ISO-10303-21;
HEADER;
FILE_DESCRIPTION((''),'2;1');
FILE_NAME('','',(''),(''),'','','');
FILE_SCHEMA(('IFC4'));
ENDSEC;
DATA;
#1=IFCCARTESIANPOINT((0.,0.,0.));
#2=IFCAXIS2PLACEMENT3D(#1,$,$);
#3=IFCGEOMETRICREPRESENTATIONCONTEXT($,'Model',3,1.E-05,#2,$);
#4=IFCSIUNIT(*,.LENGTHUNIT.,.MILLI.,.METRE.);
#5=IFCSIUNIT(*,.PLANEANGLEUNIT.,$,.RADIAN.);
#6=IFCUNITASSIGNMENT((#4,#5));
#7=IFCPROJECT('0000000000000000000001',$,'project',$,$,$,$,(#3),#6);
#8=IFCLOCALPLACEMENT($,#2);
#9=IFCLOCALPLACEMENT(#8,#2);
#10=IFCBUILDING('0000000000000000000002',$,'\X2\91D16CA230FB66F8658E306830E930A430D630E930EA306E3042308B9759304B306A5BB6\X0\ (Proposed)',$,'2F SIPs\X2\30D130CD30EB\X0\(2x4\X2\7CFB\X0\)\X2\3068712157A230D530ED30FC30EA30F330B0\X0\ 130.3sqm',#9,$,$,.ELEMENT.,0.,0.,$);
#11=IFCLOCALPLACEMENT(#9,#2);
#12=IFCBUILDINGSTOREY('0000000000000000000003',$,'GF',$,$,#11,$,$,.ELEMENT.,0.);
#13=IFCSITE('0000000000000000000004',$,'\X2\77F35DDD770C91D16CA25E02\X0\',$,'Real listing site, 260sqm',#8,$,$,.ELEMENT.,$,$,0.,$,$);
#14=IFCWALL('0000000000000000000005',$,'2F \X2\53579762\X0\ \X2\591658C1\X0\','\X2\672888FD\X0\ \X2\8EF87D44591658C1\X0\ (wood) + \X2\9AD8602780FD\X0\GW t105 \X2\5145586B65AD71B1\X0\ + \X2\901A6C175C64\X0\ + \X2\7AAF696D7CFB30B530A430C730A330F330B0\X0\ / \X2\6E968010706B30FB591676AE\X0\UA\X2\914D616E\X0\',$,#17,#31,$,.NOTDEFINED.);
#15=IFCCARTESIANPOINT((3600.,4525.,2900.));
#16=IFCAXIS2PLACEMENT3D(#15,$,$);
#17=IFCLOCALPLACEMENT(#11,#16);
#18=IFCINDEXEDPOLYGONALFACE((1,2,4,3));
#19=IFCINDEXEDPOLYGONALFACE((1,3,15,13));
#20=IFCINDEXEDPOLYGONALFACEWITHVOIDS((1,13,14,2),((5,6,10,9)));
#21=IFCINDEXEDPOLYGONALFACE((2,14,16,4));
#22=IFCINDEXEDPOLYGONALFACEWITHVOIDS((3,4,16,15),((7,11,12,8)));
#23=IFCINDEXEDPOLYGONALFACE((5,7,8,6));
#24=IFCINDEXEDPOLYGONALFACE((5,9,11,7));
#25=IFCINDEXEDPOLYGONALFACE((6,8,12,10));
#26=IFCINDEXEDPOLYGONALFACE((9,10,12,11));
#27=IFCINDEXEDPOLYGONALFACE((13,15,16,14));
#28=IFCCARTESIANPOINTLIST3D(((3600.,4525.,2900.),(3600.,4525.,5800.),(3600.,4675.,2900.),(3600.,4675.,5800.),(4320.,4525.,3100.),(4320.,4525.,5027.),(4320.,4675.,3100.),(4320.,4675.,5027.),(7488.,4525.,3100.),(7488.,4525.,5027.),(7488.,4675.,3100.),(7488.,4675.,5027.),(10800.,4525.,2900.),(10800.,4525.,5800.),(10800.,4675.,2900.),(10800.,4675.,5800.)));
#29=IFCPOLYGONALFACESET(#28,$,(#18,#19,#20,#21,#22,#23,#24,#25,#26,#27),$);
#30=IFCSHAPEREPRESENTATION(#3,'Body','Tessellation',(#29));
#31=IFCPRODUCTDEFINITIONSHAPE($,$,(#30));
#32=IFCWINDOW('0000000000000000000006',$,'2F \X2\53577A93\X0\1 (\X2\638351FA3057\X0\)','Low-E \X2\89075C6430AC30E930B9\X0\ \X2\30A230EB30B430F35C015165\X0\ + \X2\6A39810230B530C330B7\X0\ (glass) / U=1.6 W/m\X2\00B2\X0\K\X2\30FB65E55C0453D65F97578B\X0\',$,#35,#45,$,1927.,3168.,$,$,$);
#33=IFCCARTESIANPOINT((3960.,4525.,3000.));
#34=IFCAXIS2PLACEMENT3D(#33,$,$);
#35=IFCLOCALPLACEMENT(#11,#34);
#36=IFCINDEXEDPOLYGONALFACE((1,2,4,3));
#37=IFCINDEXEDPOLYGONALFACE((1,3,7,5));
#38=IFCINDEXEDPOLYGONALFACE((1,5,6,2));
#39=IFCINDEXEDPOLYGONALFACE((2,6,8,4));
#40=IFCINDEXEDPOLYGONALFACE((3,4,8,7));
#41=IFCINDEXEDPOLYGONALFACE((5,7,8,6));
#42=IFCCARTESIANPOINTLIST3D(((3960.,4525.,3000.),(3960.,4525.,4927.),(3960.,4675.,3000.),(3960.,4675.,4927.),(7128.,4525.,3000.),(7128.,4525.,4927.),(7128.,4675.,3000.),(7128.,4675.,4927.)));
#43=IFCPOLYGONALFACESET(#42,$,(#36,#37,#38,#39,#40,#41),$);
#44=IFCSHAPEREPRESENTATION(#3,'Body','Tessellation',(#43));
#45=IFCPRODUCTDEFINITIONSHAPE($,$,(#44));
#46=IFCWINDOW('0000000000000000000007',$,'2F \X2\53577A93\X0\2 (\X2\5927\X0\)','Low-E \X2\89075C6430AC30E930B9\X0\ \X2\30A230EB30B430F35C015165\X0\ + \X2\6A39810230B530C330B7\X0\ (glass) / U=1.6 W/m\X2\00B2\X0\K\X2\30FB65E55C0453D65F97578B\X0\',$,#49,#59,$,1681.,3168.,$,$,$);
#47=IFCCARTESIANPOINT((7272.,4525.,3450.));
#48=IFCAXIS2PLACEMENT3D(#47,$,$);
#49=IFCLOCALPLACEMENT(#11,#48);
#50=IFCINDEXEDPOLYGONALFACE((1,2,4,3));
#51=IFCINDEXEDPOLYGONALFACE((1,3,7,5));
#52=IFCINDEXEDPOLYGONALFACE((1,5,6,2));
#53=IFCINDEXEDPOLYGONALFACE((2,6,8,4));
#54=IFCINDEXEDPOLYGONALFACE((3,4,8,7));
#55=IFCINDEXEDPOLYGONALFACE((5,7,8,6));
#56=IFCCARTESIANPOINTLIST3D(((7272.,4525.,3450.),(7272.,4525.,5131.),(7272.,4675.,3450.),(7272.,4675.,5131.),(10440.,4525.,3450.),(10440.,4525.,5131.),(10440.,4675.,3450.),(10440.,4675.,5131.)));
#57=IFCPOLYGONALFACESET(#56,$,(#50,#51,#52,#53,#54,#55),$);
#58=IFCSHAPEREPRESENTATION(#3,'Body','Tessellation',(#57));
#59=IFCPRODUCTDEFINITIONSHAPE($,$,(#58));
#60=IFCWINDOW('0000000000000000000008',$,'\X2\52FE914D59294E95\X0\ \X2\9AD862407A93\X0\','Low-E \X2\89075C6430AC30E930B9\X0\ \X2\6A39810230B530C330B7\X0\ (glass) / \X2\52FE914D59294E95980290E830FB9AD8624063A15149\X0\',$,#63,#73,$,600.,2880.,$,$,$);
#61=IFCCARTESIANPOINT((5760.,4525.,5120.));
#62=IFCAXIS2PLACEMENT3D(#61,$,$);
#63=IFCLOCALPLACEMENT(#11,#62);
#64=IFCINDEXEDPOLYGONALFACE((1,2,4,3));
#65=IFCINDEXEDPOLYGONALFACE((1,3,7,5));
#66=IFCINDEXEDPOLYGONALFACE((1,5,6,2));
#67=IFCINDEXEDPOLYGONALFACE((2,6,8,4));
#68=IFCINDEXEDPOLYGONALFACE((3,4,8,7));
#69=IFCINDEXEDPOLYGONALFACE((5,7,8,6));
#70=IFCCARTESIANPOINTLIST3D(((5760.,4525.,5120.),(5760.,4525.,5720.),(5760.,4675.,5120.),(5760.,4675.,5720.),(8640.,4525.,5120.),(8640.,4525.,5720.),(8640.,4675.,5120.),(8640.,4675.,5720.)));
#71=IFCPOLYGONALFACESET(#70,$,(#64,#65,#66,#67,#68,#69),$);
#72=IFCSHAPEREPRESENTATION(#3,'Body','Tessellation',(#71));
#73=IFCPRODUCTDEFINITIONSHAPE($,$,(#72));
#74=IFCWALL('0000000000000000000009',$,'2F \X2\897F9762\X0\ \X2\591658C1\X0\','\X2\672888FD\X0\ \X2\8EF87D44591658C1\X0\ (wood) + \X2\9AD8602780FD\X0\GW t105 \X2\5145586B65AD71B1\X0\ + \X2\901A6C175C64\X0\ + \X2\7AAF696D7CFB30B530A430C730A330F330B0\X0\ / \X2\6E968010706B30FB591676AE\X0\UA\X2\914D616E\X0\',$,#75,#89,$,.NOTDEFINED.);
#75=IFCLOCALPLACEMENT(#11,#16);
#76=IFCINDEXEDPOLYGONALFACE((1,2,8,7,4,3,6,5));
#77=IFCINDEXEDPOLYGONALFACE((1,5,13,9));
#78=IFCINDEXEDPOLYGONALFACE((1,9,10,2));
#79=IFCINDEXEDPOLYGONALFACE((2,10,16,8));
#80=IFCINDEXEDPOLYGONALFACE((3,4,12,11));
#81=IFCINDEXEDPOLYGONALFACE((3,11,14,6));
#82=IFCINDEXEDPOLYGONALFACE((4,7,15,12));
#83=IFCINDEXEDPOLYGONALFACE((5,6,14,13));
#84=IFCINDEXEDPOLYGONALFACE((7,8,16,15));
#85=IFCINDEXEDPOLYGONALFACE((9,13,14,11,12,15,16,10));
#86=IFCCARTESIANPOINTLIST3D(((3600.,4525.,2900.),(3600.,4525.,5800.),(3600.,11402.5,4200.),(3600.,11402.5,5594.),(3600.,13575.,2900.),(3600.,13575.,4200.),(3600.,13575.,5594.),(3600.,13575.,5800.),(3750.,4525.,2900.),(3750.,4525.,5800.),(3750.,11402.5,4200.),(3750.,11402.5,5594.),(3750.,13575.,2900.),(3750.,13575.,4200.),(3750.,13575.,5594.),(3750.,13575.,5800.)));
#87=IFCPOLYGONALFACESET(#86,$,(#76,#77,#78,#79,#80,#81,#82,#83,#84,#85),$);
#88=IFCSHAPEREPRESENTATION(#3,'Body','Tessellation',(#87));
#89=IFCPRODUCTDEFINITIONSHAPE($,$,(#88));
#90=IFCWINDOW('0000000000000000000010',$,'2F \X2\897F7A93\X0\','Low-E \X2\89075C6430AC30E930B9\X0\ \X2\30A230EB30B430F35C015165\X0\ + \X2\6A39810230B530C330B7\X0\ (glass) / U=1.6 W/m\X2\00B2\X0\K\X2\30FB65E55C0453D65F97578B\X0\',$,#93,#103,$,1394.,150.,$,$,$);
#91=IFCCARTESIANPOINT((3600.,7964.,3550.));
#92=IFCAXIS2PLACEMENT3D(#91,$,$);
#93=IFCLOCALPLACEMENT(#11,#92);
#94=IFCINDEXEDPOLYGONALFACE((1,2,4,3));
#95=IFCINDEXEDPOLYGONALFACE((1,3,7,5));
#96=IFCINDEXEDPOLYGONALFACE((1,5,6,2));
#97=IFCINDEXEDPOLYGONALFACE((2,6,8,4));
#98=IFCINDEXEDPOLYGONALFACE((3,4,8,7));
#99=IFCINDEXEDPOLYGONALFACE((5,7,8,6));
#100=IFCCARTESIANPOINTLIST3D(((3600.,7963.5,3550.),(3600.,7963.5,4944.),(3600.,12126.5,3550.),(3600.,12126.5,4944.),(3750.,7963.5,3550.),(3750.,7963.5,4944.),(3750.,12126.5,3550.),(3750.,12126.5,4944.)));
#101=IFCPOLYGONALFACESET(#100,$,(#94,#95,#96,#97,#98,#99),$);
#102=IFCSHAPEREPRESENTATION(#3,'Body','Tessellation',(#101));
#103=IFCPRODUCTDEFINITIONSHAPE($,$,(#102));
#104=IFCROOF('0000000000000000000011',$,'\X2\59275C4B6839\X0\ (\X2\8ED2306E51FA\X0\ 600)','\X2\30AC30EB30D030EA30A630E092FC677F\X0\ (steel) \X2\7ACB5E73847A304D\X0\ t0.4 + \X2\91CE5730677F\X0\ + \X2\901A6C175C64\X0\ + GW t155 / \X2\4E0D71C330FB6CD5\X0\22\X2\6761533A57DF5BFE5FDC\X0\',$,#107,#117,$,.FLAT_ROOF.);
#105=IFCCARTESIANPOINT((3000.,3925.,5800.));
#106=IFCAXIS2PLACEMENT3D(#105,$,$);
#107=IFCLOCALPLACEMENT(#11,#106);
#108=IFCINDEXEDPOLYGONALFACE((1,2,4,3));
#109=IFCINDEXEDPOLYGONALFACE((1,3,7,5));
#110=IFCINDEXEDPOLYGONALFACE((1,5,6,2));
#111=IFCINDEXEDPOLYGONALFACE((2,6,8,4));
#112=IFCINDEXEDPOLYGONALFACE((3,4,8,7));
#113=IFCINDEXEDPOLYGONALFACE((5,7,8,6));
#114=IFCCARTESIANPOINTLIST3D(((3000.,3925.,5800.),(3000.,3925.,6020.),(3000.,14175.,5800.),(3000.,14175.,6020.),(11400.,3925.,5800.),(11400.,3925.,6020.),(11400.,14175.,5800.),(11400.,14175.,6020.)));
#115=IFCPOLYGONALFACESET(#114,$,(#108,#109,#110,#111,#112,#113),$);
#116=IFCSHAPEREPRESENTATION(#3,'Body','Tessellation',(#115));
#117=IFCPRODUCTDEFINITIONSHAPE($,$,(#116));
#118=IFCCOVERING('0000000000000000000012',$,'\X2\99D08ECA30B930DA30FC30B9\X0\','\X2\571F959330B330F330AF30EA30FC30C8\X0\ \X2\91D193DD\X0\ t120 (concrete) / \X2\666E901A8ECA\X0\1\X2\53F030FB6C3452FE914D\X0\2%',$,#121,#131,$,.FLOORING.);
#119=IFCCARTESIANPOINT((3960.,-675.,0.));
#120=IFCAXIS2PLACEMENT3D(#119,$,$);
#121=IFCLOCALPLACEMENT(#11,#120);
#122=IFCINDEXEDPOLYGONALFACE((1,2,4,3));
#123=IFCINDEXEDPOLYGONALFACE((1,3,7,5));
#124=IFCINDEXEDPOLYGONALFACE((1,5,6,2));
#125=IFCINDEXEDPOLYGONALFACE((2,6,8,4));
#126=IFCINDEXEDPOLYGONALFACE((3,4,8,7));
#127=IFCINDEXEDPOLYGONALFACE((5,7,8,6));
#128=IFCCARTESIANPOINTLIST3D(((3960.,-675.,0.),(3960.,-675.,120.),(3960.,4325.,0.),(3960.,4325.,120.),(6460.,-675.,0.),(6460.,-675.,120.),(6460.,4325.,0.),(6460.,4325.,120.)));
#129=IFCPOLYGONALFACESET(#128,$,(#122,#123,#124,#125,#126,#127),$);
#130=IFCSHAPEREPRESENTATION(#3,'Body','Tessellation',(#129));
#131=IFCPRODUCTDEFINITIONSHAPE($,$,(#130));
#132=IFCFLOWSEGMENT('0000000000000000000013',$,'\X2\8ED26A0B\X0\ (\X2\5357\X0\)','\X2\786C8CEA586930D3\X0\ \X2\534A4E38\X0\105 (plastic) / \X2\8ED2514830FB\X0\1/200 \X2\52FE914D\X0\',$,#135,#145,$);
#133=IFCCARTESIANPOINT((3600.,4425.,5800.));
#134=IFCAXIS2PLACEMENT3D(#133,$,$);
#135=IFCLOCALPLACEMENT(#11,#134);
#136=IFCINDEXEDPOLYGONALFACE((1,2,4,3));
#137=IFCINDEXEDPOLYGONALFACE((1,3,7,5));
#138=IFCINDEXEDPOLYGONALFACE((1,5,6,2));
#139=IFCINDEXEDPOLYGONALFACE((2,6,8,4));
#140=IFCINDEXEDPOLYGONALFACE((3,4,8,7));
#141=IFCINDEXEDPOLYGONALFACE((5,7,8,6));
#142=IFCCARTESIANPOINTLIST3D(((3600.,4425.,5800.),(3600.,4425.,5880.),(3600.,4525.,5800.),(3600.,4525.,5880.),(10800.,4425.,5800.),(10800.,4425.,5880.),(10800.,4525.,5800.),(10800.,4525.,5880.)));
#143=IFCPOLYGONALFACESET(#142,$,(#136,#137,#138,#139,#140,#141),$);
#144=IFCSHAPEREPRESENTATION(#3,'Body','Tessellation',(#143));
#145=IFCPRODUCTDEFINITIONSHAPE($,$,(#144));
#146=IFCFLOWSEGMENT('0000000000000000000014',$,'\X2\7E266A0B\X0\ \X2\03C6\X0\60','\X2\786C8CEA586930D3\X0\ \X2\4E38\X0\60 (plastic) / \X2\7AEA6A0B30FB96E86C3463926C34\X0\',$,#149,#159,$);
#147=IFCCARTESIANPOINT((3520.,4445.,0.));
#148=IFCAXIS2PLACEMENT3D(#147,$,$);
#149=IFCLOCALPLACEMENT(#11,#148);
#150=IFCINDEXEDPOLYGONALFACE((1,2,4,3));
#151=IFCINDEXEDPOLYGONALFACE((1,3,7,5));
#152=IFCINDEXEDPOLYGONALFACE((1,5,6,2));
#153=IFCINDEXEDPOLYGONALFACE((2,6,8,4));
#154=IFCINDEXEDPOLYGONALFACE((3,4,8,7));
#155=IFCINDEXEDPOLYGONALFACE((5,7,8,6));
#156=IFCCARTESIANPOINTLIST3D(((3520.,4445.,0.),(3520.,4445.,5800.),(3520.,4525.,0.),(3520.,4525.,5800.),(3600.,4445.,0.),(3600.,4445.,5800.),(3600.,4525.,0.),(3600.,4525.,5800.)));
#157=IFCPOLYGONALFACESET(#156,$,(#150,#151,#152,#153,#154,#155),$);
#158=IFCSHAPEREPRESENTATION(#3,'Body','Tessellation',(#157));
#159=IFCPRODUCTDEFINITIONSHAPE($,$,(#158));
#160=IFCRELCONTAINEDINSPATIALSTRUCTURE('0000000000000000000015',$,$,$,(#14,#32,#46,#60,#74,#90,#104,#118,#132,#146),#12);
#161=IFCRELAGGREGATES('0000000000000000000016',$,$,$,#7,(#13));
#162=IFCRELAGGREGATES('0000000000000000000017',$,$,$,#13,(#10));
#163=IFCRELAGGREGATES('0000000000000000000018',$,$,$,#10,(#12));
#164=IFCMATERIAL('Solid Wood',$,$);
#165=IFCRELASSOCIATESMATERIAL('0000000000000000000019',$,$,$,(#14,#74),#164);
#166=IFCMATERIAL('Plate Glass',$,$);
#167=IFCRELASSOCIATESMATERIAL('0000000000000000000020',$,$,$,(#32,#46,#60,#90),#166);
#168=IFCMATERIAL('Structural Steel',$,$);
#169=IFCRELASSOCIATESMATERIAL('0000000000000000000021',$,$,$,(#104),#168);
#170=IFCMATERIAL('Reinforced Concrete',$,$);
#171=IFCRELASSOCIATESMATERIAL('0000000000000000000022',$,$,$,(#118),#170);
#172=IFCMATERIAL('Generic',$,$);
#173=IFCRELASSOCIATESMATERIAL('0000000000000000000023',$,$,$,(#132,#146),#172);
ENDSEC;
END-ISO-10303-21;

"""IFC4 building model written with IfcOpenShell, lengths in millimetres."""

from ifc_helpers import new_model, si_unit, frame, frame_2d, origin, place, context, project, spatial, rectangle, extrude, material, element, fill, save


model = new_model("IFC4")

# Units and contexts
model_context = context("Model", 3, precision=1e-05, world=origin())
ifc_project = project(units=[si_unit("LENGTHUNIT", "METRE", prefix="MILLI"), si_unit("PLANEANGLEUNIT", "RADIAN")], contexts=[model_context])

# Site, building, storey
site_placement = place(None, origin())
site = spatial("IfcSite", under=ifc_project, at=site_placement, Name="石川県金沢市", ObjectType="Real listing site, 260sqm", CompositionType="ELEMENT", RefElevation=0.0)
building_placement = place(site_placement, origin())
building = spatial("IfcBuilding", under=site, at=building_placement, Name="金沢・書斎とライブラリのある静かな家 (Proposed)", ObjectType="2F SIPsパネル(2x4系)と無垢フローリング 130.3sqm", CompositionType="ELEMENT", ElevationOfRefHeight=0.0, ElevationOfTerrain=0.0)
storey_placement = place(building_placement, origin())
storey = spatial("IfcBuildingStorey", under=building, at=storey_placement, Name="GF", CompositionType="ELEMENT", Elevation=0.0)

# Shared definitions
ifc_material_1 = material(Name="Solid Wood")

# Shared definitions
ifc_material_2 = material(Name="Reinforced Concrete")

# Shared definitions
ifc_material_3 = material(Name="Plate Glass")

# Wall, openings, windows
wall_1_placement = place(storey_placement, frame((3600.0, 4525.0, 2900.0)))
wall_1 = element("IfcWall", 1, at=wall_1_placement, inside=storey, material=ifc_material_1, Name="2F 南面 外壁", Description="木製 軸組外壁 (wood) + 高性能GW t105 充填断熱 + 通気層 + 窯業系サイディング / 準耐火・外皮UA配慮", PredefinedType="NOTDEFINED", context=model_context, shape_type="SweptSolid", body=[
    extrude(rectangle(XDim=7200.0, YDim=150.0, at=frame_2d((3600.0, 75.0))), frame((3600.0, 4525.0, 2900.0)), (0.0, 0.0, 1.0), 2900.0),
])
opening_1_placement = place(storey_placement, frame((3960.0, 4525.0, 3000.0)))
opening_1 = element("IfcOpeningElement", 2, at=opening_1_placement, cuts=wall_1, PredefinedType="NOTDEFINED", context=model_context, shape_type="SweptSolid", body=[
    extrude(rectangle(XDim=3168.0, YDim=150.0, at=frame_2d((1584.0, 75.0))), frame((3960.0, 4525.0, 3000.0)), (0.0, 0.0, 1.0), 1927.0),
])
opening_2_placement = place(storey_placement, frame((7272.0, 4525.0, 3450.0)))
opening_2 = element("IfcOpeningElement", 3, at=opening_2_placement, cuts=wall_1, PredefinedType="NOTDEFINED", context=model_context, shape_type="SweptSolid", body=[
    extrude(rectangle(XDim=3168.0, YDim=150.0, at=frame_2d((1584.0, 75.0))), frame((7272.0, 4525.0, 3450.0)), (0.0, 0.0, 1.0), 1681.0),
])
opening_3_placement = place(storey_placement, frame((5760.0, 4525.0, 5120.0)))
opening_3 = element("IfcOpeningElement", 4, at=opening_3_placement, cuts=wall_1, PredefinedType="NOTDEFINED", context=model_context, shape_type="SweptSolid", body=[
    extrude(rectangle(XDim=2880.0, YDim=150.0, at=frame_2d((1440.0, 75.0))), frame((5760.0, 4525.0, 5120.0)), (0.0, 0.0, 1.0), 600.0),
])
window_1_placement = place(storey_placement, frame((3960.0, 4525.0, 3000.0)))
window_1 = element("IfcWindow", 5, at=window_1_placement, inside=storey, material=ifc_material_3, Name="2F 南窓1 (掃出し)", Description="Low-E 複層ガラス アルゴン封入 + 樹脂サッシ (glass) / U=1.6 W/m²K・日射取得型", OverallHeight=1927.0, OverallWidth=3168.0, context=model_context, shape_type="SweptSolid", body=[
    extrude(rectangle(XDim=3168.0, YDim=150.0, at=frame_2d((1584.0, 75.0))), frame((3960.0, 4525.0, 3000.0)), (0.0, 0.0, 1.0), 1927.0),
])
fill(opening_1, window_1)
window_2_placement = place(storey_placement, frame((7272.0, 4525.0, 3450.0)))
window_2 = element("IfcWindow", 6, at=window_2_placement, inside=storey, material=ifc_material_3, Name="2F 南窓2 (大)", Description="Low-E 複層ガラス アルゴン封入 + 樹脂サッシ (glass) / U=1.6 W/m²K・日射取得型", OverallHeight=1681.0, OverallWidth=3168.0, context=model_context, shape_type="SweptSolid", body=[
    extrude(rectangle(XDim=3168.0, YDim=150.0, at=frame_2d((1584.0, 75.0))), frame((7272.0, 4525.0, 3450.0)), (0.0, 0.0, 1.0), 1681.0),
])
fill(opening_2, window_2)
window_3_placement = place(storey_placement, frame((5760.0, 4525.0, 5120.0)))
window_3 = element("IfcWindow", 7, at=window_3_placement, inside=storey, material=ifc_material_3, Name="勾配天井 高所窓", Description="Low-E 複層ガラス 樹脂サッシ (glass) / 勾配天井頂部・高所採光", OverallHeight=600.0, OverallWidth=2880.0, context=model_context, shape_type="SweptSolid", body=[
    extrude(rectangle(XDim=2880.0, YDim=150.0, at=frame_2d((1440.0, 75.0))), frame((5760.0, 4525.0, 5120.0)), (0.0, 0.0, 1.0), 600.0),
])
fill(opening_3, window_3)

# Wall, opening, window
wall_2_placement = place(storey_placement, frame((3600.0, 4525.0, 2900.0)))
wall_2 = element("IfcWall", 8, at=wall_2_placement, inside=storey, material=ifc_material_1, Name="2F 西面 外壁", Description="木製 軸組外壁 (wood) + 高性能GW t105 充填断熱 + 通気層 + 窯業系サイディング / 準耐火・外皮UA配慮", PredefinedType="NOTDEFINED", context=model_context, shape_type="SweptSolid", body=[
    extrude(rectangle(XDim=150.0, YDim=9050.0, at=frame_2d((75.0, 4525.0))), frame((3600.0, 4525.0, 2900.0)), (0.0, 0.0, 1.0), 2900.0),
])
opening_4_placement = place(storey_placement, frame((3600.0, 7964.0, 3550.0)))
opening_4 = element("IfcOpeningElement", 9, at=opening_4_placement, cuts=wall_2, PredefinedType="NOTDEFINED", context=model_context, shape_type="SweptSolid", body=[
    extrude(rectangle(XDim=150.0, YDim=4163.0, at=frame_2d((75.0, 2081.0))), frame((3600.0, 7964.0, 3550.0)), (0.0, 0.0, 1.0), 1394.0),
])
window_4_placement = place(storey_placement, frame((3600.0, 7964.0, 3550.0)))
window_4 = element("IfcWindow", 10, at=window_4_placement, inside=storey, material=ifc_material_3, Name="2F 西窓", Description="Low-E 複層ガラス アルゴン封入 + 樹脂サッシ (glass) / U=1.6 W/m²K・日射取得型", OverallHeight=1394.0, OverallWidth=150.0, context=model_context, shape_type="SweptSolid", body=[
    extrude(rectangle(XDim=150.0, YDim=4163.0, at=frame_2d((75.0, 2081.0))), frame((3600.0, 7964.0, 3550.0)), (0.0, 0.0, 1.0), 1394.0),
])
fill(opening_4, window_4)

# Roof
ifc_material_4 = material(Name="Structural Steel")
roof_placement = place(storey_placement, frame((3000.0, 3925.0, 5800.0)))
element("IfcRoof", 11, at=roof_placement, inside=storey, material=ifc_material_4, Name="大屋根 (軒の出 600)", Description="ガルバリウム鋼板 (steel) 立平葺き t0.4 + 野地板 + 通気層 + GW t155 / 不燃・法22条区域対応", PredefinedType="FLAT_ROOF", context=model_context, shape_type="SweptSolid", body=[
    extrude(rectangle(XDim=8400.0, YDim=10250.0, at=frame_2d((4200.0, 5125.0))), frame((3000.0, 3925.0, 5800.0)), (0.0, 0.0, 1.0), 220.0),
])

# Covering
covering_placement = place(storey_placement, frame((3960.0, -675.0, 0.0)))
element("IfcCovering", 12, at=covering_placement, inside=storey, material=ifc_material_2, Name="駐車スペース", Description="土間コンクリート 金鏝 t120 (concrete) / 普通車1台・水勾配2%", PredefinedType="FLOORING", context=model_context, shape_type="SweptSolid", body=[
    extrude(rectangle(XDim=2500.0, YDim=5000.0, at=frame_2d((1250.0, 2500.0))), frame((3960.0, -675.0, 0.0)), (0.0, 0.0, 1.0), 120.0),
])

# Flow segments
ifc_material_5 = material(Name="Generic")
flow_segment_1_placement = place(storey_placement, frame((3600.0, 4425.0, 5800.0)))
element("IfcFlowSegment", 13, at=flow_segment_1_placement, inside=storey, material=ifc_material_5, Name="軒樋 (南)", Description="硬質塩ビ 半丸105 (plastic) / 軒先・1/200 勾配", context=model_context, shape_type="SweptSolid", body=[
    extrude(rectangle(XDim=7200.0, YDim=100.0, at=frame_2d((3600.0, 50.0))), frame((3600.0, 4425.0, 5800.0)), (0.0, 0.0, 1.0), 80.0),
])
flow_segment_2_placement = place(storey_placement, frame((3520.0, 4445.0, 0.0)))
element("IfcFlowSegment", 14, at=flow_segment_2_placement, inside=storey, material=ifc_material_5, Name="縦樋 φ60", Description="硬質塩ビ 丸60 (plastic) / 竪樋・雨水排水", context=model_context, shape_type="SweptSolid", body=[
    extrude(rectangle(XDim=80.0, YDim=80.0, at=frame_2d((40.0, 40.0))), frame((3520.0, 4445.0, 0.0)), (0.0, 0.0, 1.0), 5800.0),
])

save(model, "model.ifc")
